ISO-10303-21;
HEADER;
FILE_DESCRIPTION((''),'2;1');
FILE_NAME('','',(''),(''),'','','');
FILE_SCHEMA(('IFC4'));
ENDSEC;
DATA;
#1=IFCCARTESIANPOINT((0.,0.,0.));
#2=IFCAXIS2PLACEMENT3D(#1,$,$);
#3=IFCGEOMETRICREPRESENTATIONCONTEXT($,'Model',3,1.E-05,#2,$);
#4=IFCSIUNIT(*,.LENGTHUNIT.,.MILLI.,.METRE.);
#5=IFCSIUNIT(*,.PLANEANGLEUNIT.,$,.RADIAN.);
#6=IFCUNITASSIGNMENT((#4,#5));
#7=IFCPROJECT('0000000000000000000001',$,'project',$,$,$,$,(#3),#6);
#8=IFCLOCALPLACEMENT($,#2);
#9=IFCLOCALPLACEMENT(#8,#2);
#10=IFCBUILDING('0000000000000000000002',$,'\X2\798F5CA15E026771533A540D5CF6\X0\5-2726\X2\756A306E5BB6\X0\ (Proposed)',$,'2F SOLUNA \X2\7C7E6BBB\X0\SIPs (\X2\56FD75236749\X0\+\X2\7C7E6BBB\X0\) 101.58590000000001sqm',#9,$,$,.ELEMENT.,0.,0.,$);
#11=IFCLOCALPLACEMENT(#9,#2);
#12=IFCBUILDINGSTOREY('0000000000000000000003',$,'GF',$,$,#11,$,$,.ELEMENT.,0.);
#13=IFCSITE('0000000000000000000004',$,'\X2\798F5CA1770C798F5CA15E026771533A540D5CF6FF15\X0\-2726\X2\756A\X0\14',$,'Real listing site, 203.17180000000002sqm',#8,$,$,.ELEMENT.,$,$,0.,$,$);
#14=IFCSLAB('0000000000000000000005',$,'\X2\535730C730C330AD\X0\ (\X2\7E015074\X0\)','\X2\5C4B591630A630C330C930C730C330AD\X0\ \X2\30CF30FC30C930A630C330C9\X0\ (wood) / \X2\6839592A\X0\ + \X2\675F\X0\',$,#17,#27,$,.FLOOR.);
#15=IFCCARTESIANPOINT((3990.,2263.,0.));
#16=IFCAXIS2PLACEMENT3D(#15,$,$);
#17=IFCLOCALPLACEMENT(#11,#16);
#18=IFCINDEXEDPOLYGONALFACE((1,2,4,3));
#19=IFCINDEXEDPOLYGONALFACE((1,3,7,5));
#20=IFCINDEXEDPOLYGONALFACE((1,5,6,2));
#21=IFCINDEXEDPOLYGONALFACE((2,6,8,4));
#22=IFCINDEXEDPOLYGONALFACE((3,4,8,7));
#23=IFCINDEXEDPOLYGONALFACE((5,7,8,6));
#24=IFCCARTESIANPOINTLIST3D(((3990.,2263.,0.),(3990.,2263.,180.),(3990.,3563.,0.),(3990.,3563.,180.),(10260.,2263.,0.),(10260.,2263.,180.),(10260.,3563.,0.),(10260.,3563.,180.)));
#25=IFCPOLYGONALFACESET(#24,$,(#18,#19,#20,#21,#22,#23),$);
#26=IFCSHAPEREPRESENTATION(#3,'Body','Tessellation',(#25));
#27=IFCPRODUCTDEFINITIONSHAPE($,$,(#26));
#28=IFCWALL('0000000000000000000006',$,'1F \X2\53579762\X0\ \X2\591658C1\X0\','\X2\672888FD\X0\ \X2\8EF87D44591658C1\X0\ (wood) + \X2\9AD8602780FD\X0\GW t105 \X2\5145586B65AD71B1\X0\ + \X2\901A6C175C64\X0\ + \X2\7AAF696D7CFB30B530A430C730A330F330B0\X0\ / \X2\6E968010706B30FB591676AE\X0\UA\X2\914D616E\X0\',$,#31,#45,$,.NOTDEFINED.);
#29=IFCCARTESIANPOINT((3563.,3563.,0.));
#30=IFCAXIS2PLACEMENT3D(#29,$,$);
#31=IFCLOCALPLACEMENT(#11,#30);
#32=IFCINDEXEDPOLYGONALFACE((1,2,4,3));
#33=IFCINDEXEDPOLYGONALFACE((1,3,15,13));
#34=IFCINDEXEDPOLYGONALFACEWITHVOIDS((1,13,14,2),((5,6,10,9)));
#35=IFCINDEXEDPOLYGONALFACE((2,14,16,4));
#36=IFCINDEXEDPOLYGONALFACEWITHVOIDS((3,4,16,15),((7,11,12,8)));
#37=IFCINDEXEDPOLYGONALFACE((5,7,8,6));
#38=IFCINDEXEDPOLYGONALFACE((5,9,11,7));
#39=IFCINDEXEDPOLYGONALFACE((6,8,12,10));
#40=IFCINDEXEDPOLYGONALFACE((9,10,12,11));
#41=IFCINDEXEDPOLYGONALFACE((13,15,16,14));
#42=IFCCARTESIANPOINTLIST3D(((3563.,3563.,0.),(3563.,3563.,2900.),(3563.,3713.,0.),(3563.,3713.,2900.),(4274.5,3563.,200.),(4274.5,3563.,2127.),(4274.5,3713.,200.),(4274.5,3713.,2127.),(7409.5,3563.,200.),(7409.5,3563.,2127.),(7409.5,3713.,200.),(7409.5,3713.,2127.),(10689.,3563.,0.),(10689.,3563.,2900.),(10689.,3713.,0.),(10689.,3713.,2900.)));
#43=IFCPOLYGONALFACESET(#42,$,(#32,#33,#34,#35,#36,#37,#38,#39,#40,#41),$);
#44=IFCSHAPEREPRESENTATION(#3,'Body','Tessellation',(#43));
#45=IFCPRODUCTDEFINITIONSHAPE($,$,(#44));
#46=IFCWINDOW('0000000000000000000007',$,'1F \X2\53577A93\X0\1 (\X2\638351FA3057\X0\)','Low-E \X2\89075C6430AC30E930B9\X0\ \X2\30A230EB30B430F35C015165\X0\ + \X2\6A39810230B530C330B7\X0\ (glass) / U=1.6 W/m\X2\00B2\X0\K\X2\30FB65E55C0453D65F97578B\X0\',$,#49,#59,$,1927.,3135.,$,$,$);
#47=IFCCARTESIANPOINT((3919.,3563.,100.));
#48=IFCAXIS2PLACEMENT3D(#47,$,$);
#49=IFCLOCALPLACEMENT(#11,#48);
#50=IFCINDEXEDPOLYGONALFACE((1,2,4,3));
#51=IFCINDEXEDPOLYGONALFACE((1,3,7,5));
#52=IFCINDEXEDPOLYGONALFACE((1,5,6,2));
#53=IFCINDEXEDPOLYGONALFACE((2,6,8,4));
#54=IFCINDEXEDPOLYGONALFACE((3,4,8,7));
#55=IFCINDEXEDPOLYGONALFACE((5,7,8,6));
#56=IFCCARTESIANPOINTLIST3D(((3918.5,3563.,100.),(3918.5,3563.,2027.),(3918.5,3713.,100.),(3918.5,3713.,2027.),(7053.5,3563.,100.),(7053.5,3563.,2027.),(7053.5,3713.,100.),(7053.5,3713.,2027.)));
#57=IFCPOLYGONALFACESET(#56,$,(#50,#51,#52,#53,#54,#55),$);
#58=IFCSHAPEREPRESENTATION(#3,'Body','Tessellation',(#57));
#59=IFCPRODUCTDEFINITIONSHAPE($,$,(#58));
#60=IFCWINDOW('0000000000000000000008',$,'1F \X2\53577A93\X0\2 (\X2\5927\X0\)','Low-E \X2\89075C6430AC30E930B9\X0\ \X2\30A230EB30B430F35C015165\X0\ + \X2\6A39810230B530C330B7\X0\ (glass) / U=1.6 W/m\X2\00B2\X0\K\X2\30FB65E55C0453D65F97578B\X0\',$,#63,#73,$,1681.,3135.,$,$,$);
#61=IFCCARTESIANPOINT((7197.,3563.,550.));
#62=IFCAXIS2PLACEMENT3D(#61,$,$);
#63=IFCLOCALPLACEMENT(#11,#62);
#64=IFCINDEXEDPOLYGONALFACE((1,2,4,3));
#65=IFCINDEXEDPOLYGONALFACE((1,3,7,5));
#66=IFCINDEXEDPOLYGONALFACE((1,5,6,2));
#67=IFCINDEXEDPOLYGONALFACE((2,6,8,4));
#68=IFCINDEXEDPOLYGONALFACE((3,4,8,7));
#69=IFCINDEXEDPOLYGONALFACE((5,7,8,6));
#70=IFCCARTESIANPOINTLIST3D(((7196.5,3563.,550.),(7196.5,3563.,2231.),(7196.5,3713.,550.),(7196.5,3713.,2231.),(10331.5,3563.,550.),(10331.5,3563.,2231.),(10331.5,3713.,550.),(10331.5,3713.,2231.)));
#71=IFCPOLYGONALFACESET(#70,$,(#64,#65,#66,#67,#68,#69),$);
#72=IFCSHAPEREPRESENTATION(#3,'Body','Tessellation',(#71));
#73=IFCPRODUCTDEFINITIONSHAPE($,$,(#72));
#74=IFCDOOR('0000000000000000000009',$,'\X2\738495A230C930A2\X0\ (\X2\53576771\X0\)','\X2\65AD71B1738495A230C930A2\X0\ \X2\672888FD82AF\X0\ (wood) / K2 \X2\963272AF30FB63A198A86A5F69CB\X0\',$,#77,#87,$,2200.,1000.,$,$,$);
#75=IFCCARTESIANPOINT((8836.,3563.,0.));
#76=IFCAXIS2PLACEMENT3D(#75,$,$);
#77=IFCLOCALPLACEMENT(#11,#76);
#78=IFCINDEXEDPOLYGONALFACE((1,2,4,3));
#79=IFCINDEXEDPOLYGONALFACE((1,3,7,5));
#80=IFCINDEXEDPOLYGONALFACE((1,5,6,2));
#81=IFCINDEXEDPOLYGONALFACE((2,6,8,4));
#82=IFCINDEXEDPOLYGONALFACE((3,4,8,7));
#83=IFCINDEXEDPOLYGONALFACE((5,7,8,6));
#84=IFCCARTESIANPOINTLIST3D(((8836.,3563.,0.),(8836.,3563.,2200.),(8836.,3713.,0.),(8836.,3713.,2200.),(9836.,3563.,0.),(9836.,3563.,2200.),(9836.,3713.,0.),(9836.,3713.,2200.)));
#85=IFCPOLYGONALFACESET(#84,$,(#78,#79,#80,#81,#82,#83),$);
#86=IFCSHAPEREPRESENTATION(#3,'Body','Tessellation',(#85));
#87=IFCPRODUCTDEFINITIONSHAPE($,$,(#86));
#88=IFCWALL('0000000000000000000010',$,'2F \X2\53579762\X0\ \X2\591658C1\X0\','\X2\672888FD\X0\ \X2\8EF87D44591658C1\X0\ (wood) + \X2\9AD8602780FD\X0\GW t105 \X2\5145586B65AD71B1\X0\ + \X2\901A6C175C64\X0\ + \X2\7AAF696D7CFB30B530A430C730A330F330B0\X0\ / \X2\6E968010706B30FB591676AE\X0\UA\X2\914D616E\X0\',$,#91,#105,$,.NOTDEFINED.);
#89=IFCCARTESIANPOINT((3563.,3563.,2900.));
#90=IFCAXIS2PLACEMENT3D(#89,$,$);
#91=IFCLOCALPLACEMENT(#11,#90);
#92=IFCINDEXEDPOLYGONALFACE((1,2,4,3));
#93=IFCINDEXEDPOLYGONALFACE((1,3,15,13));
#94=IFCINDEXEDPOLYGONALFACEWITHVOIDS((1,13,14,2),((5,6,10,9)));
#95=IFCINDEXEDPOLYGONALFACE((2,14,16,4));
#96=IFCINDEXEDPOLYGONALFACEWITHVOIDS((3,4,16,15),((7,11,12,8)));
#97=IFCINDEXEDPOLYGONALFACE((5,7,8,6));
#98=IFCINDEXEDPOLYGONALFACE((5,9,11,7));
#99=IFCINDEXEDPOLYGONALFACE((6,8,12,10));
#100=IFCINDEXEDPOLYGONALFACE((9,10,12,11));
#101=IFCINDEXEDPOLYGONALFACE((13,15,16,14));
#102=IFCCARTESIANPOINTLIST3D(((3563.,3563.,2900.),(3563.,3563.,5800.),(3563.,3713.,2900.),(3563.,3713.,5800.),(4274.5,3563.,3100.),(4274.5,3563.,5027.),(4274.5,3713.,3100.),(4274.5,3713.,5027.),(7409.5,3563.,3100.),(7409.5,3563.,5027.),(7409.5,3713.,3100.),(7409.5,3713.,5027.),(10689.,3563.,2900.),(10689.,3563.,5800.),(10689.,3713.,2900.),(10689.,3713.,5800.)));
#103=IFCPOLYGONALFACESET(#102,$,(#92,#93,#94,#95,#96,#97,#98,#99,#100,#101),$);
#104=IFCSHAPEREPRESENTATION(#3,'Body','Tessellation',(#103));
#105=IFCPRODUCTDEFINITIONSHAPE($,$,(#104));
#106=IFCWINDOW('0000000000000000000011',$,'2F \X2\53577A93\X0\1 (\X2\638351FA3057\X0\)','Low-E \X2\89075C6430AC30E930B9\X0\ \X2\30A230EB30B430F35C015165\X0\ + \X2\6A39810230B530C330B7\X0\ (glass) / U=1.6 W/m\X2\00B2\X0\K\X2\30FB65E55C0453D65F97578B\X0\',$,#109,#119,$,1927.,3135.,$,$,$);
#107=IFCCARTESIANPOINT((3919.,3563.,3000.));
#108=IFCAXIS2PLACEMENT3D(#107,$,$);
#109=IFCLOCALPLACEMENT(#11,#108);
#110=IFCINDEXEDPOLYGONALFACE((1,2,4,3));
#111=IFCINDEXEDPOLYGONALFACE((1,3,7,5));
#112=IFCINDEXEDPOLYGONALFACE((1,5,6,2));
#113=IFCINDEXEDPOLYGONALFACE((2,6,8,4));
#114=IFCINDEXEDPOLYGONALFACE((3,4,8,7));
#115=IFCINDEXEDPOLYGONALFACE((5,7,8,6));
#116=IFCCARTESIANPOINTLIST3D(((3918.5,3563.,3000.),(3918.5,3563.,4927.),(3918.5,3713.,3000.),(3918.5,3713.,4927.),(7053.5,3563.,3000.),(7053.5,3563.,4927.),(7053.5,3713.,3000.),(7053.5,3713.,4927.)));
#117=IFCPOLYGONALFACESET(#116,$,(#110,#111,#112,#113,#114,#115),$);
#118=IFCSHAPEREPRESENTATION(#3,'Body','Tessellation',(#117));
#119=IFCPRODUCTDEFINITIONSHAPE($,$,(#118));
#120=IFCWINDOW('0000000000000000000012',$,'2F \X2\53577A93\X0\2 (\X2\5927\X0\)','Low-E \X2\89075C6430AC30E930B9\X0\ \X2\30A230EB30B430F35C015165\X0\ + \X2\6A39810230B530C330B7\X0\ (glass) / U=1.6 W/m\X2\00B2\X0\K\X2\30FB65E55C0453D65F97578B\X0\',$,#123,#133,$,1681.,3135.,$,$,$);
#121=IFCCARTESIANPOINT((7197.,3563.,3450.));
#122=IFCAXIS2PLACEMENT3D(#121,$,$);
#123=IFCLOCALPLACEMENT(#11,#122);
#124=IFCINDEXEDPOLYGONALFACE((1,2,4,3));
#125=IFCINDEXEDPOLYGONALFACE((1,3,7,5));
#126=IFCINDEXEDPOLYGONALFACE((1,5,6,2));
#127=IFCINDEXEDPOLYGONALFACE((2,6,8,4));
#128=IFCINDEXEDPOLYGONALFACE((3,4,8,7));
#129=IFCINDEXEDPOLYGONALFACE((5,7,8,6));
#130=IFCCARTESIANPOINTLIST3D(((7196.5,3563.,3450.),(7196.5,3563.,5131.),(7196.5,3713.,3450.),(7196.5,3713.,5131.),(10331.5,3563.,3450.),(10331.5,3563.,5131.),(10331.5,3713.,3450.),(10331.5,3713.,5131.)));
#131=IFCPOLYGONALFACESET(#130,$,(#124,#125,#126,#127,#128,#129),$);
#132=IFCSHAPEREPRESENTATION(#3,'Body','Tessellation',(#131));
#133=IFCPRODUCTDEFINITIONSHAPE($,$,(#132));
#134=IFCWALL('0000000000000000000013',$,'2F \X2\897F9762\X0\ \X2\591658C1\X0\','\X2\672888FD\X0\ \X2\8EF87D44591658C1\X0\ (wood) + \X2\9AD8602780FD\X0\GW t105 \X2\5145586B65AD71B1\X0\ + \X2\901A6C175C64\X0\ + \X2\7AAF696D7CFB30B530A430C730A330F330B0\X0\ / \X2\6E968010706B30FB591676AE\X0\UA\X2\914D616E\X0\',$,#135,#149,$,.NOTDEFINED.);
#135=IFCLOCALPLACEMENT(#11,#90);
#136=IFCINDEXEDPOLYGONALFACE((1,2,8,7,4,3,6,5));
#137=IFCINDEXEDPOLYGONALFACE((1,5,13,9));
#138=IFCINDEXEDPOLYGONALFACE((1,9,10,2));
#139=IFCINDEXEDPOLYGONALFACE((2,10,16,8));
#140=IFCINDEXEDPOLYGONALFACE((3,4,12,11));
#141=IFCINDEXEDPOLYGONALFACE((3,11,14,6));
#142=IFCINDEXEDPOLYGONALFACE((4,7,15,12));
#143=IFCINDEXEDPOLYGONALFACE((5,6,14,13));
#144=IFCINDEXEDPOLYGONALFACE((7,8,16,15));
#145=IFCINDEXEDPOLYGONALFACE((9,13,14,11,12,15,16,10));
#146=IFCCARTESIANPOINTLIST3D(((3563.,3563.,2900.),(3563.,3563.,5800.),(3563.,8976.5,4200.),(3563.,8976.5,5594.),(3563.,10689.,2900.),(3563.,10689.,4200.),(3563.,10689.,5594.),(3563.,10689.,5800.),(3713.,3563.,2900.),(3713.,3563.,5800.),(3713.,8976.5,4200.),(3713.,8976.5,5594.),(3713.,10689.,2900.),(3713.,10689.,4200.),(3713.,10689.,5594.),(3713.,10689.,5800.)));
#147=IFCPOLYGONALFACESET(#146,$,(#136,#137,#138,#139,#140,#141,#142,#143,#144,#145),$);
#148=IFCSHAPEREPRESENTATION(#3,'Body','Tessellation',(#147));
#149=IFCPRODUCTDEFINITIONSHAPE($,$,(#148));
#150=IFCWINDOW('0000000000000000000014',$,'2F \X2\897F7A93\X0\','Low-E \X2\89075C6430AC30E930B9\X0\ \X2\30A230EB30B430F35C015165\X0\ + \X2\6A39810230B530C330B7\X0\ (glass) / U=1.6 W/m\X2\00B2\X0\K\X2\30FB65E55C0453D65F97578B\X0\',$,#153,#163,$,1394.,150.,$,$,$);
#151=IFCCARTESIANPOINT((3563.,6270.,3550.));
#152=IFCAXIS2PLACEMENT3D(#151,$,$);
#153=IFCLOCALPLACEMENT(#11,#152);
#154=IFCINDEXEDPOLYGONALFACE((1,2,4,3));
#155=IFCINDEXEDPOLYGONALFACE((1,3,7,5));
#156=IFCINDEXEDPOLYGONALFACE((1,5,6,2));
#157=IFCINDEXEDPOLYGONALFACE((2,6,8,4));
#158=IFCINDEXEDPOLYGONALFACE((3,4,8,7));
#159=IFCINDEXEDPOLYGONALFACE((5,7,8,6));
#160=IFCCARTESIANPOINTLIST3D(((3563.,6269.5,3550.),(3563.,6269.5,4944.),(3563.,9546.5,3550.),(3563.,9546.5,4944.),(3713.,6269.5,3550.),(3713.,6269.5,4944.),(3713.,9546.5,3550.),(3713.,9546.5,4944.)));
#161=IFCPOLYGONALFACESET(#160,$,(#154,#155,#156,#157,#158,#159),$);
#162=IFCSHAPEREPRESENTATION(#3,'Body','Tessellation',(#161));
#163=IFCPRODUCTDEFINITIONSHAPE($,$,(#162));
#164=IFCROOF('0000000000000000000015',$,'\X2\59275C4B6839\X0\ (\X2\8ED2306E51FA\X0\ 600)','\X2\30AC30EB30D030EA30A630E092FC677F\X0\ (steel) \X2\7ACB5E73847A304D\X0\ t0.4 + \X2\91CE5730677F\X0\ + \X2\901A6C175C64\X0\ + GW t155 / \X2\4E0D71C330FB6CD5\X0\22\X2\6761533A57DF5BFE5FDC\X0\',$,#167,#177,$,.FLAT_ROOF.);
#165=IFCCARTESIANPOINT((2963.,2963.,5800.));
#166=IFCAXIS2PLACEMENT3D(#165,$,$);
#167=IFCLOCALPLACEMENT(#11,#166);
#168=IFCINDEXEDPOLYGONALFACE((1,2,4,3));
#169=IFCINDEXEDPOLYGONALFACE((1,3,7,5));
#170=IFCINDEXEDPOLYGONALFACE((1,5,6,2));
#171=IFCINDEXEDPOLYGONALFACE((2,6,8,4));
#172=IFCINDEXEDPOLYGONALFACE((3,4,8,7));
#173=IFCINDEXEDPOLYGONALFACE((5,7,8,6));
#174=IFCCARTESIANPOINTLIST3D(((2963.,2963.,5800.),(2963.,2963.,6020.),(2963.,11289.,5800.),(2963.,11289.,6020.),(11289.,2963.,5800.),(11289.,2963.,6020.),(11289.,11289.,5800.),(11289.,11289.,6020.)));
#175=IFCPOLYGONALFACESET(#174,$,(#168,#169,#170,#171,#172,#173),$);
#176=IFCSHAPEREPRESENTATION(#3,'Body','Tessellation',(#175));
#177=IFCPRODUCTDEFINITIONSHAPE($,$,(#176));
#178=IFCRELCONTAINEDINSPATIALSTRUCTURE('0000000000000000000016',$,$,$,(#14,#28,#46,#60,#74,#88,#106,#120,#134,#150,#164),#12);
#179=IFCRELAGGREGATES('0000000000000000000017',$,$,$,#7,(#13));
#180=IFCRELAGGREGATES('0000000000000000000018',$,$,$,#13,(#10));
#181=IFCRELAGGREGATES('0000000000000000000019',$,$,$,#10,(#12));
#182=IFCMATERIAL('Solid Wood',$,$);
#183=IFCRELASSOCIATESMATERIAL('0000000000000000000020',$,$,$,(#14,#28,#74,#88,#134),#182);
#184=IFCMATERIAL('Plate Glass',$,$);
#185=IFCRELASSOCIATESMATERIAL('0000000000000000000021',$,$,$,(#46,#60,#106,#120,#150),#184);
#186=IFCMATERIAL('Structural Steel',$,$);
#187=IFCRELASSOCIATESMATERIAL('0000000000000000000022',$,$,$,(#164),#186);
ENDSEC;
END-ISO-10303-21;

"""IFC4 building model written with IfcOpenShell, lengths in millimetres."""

from ifc_helpers import new_model, si_unit, frame, frame_2d, origin, place, context, project, spatial, rectangle, extrude, material, element, fill, save


model = new_model("IFC4")

# Units and contexts
model_context = context("Model", 3, precision=1e-05, world=origin())
ifc_project = project(units=[si_unit("LENGTHUNIT", "METRE", prefix="MILLI"), si_unit("PLANEANGLEUNIT", "RADIAN")], contexts=[model_context])

# Site, building, storey
site_placement = place(None, origin())
site = spatial("IfcSite", under=ifc_project, at=site_placement, Name="福岡県福岡市東区名島５-2726番14", ObjectType="Real listing site, 203.17180000000002sqm", CompositionType="ELEMENT", RefElevation=0.0)
building_placement = place(site_placement, origin())
building = spatial("IfcBuilding", under=site, at=building_placement, Name="福岡市東区名島5-2726番の家 (Proposed)", ObjectType="2F SOLUNA 籾殻SIPs (国産杉+籾殻) 101.58590000000001sqm", CompositionType="ELEMENT", ElevationOfRefHeight=0.0, ElevationOfTerrain=0.0)
storey_placement = place(building_placement, origin())
storey = spatial("IfcBuildingStorey", under=building, at=storey_placement, Name="GF", CompositionType="ELEMENT", Elevation=0.0)

# Slab
ifc_material_1 = material(Name="Solid Wood")
slab_1_placement = place(storey_placement, frame((3990.0, 2263.0, 0.0)))
element("IfcSlab", 1, at=slab_1_placement, inside=storey, material=ifc_material_1, Name="南デッキ (縁側)", Description="屋外ウッドデッキ ハードウッド (wood) / 根太 + 束", PredefinedType="FLOOR", context=model_context, shape_type="SweptSolid", body=[
    extrude(rectangle(XDim=6270.0, YDim=1300.0, at=frame_2d((3135.0, 650.0))), frame((3990.0, 2263.0, 0.0)), (0.0, 0.0, 1.0), 180.0),
])

# Wall, openings, windows, door
wall_1_placement = place(storey_placement, frame((3563.0, 3563.0, 0.0)))
wall_1 = element("IfcWall", 2, at=wall_1_placement, inside=storey, material=ifc_material_1, Name="1F 南面 外壁", Description="木製 軸組外壁 (wood) + 高性能GW t105 充填断熱 + 通気層 + 窯業系サイディング / 準耐火・外皮UA配慮", PredefinedType="NOTDEFINED", context=model_context, shape_type="SweptSolid", body=[
    extrude(rectangle(XDim=7126.0, YDim=150.0, at=frame_2d((3563.0, 75.0))), frame((3563.0, 3563.0, 0.0)), (0.0, 0.0, 1.0), 2900.0),
])
opening_1_placement = place(storey_placement, frame((3919.0, 3563.0, 100.0)))
opening_1 = element("IfcOpeningElement", 3, at=opening_1_placement, cuts=wall_1, PredefinedType="NOTDEFINED", context=model_context, shape_type="SweptSolid", body=[
    extrude(rectangle(XDim=3135.0, YDim=150.0, at=frame_2d((1567.0, 75.0))), frame((3919.0, 3563.0, 100.0)), (0.0, 0.0, 1.0), 1927.0),
])
opening_2_placement = place(storey_placement, frame((7197.0, 3563.0, 550.0)))
opening_2 = element("IfcOpeningElement", 4, at=opening_2_placement, cuts=wall_1, PredefinedType="NOTDEFINED", context=model_context, shape_type="SweptSolid", body=[
    extrude(rectangle(XDim=3135.0, YDim=150.0, at=frame_2d((1567.0, 75.0))), frame((7197.0, 3563.0, 550.0)), (0.0, 0.0, 1.0), 1681.0),
])
opening_3_placement = place(storey_placement, frame((8836.0, 3563.0, 0.0)))
opening_3 = element("IfcOpeningElement", 5, at=opening_3_placement, cuts=wall_1, PredefinedType="NOTDEFINED", context=model_context, shape_type="SweptSolid", body=[
    extrude(rectangle(XDim=1000.0, YDim=150.0, at=frame_2d((500.0, 75.0))), frame((8836.0, 3563.0, 0.0)), (0.0, 0.0, 1.0), 2200.0),
])
ifc_material_2 = material(Name="Plate Glass")
window_1_placement = place(storey_placement, frame((3919.0, 3563.0, 100.0)))
window_1 = element("IfcWindow", 6, at=window_1_placement, inside=storey, material=ifc_material_2, Name="1F 南窓1 (掃出し)", Description="Low-E 複層ガラス アルゴン封入 + 樹脂サッシ (glass) / U=1.6 W/m²K・日射取得型", OverallHeight=1927.0, OverallWidth=3135.0, context=model_context, shape_type="SweptSolid", body=[
    extrude(rectangle(XDim=3135.0, YDim=150.0, at=frame_2d((1567.0, 75.0))), frame((3919.0, 3563.0, 100.0)), (0.0, 0.0, 1.0), 1927.0),
])
fill(opening_1, window_1)
window_2_placement = place(storey_placement, frame((7197.0, 3563.0, 550.0)))
window_2 = element("IfcWindow", 7, at=window_2_placement, inside=storey, material=ifc_material_2, Name="1F 南窓2 (大)", Description="Low-E 複層ガラス アルゴン封入 + 樹脂サッシ (glass) / U=1.6 W/m²K・日射取得型", OverallHeight=1681.0, OverallWidth=3135.0, context=model_context, shape_type="SweptSolid", body=[
    extrude(rectangle(XDim=3135.0, YDim=150.0, at=frame_2d((1567.0, 75.0))), frame((7197.0, 3563.0, 550.0)), (0.0, 0.0, 1.0), 1681.0),
])
fill(opening_2, window_2)
door_placement = place(storey_placement, frame((8836.0, 3563.0, 0.0)))
door = element("IfcDoor", 8, at=door_placement, inside=storey, material=ifc_material_1, Name="玄関ドア (南東)", Description="断熱玄関ドア 木製芯 (wood) / K2 防犯・採風機構", OverallHeight=2200.0, OverallWidth=1000.0, context=model_context, shape_type="SweptSolid", body=[
    extrude(rectangle(XDim=1000.0, YDim=150.0, at=frame_2d((500.0, 75.0))), frame((8836.0, 3563.0, 0.0)), (0.0, 0.0, 1.0), 2200.0),
])
fill(opening_3, door)

# Wall, openings, windows
wall_2_placement = place(storey_placement, frame((3563.0, 3563.0, 2900.0)))
wall_2 = element("IfcWall", 9, at=wall_2_placement, inside=storey, material=ifc_material_1, Name="2F 南面 外壁", Description="木製 軸組外壁 (wood) + 高性能GW t105 充填断熱 + 通気層 + 窯業系サイディング / 準耐火・外皮UA配慮", PredefinedType="NOTDEFINED", context=model_context, shape_type="SweptSolid", body=[
    extrude(rectangle(XDim=7126.0, YDim=150.0, at=frame_2d((3563.0, 75.0))), frame((3563.0, 3563.0, 2900.0)), (0.0, 0.0, 1.0), 2900.0),
])
opening_4_placement = place(storey_placement, frame((3919.0, 3563.0, 3000.0)))
opening_4 = element("IfcOpeningElement", 10, at=opening_4_placement, cuts=wall_2, PredefinedType="NOTDEFINED", context=model_context, shape_type="SweptSolid", body=[
    extrude(rectangle(XDim=3135.0, YDim=150.0, at=frame_2d((1567.0, 75.0))), frame((3919.0, 3563.0, 3000.0)), (0.0, 0.0, 1.0), 1927.0),
])
opening_5_placement = place(storey_placement, frame((7197.0, 3563.0, 3450.0)))
opening_5 = element("IfcOpeningElement", 11, at=opening_5_placement, cuts=wall_2, PredefinedType="NOTDEFINED", context=model_context, shape_type="SweptSolid", body=[
    extrude(rectangle(XDim=3135.0, YDim=150.0, at=frame_2d((1567.0, 75.0))), frame((7197.0, 3563.0, 3450.0)), (0.0, 0.0, 1.0), 1681.0),
])
window_3_placement = place(storey_placement, frame((3919.0, 3563.0, 3000.0)))
window_3 = element("IfcWindow", 12, at=window_3_placement, inside=storey, material=ifc_material_2, Name="2F 南窓1 (掃出し)", Description="Low-E 複層ガラス アルゴン封入 + 樹脂サッシ (glass) / U=1.6 W/m²K・日射取得型", OverallHeight=1927.0, OverallWidth=3135.0, context=model_context, shape_type="SweptSolid", body=[
    extrude(rectangle(XDim=3135.0, YDim=150.0, at=frame_2d((1567.0, 75.0))), frame((3919.0, 3563.0, 3000.0)), (0.0, 0.0, 1.0), 1927.0),
])
fill(opening_4, window_3)
window_4_placement = place(storey_placement, frame((7197.0, 3563.0, 3450.0)))
window_4 = element("IfcWindow", 13, at=window_4_placement, inside=storey, material=ifc_material_2, Name="2F 南窓2 (大)", Description="Low-E 複層ガラス アルゴン封入 + 樹脂サッシ (glass) / U=1.6 W/m²K・日射取得型", OverallHeight=1681.0, OverallWidth=3135.0, context=model_context, shape_type="SweptSolid", body=[
    extrude(rectangle(XDim=3135.0, YDim=150.0, at=frame_2d((1567.0, 75.0))), frame((7197.0, 3563.0, 3450.0)), (0.0, 0.0, 1.0), 1681.0),
])
fill(opening_5, window_4)

# Wall, opening, window
wall_3_placement = place(storey_placement, frame((3563.0, 3563.0, 2900.0)))
wall_3 = element("IfcWall", 14, at=wall_3_placement, inside=storey, material=ifc_material_1, Name="2F 西面 外壁", Description="木製 軸組外壁 (wood) + 高性能GW t105 充填断熱 + 通気層 + 窯業系サイディング / 準耐火・外皮UA配慮", PredefinedType="NOTDEFINED", context=model_context, shape_type="SweptSolid", body=[
    extrude(rectangle(XDim=150.0, YDim=7126.0, at=frame_2d((75.0, 3563.0))), frame((3563.0, 3563.0, 2900.0)), (0.0, 0.0, 1.0), 2900.0),
])
opening_6_placement = place(storey_placement, frame((3563.0, 6270.0, 3550.0)))
opening_6 = element("IfcOpeningElement", 15, at=opening_6_placement, cuts=wall_3, PredefinedType="NOTDEFINED", context=model_context, shape_type="SweptSolid", body=[
    extrude(rectangle(XDim=150.0, YDim=3277.0, at=frame_2d((75.0, 1638.0))), frame((3563.0, 6270.0, 3550.0)), (0.0, 0.0, 1.0), 1394.0),
])
window_5_placement = place(storey_placement, frame((3563.0, 6270.0, 3550.0)))
window_5 = element("IfcWindow", 16, at=window_5_placement, inside=storey, material=ifc_material_2, Name="2F 西窓", Description="Low-E 複層ガラス アルゴン封入 + 樹脂サッシ (glass) / U=1.6 W/m²K・日射取得型", OverallHeight=1394.0, OverallWidth=150.0, context=model_context, shape_type="SweptSolid", body=[
    extrude(rectangle(XDim=150.0, YDim=3277.0, at=frame_2d((75.0, 1638.0))), frame((3563.0, 6270.0, 3550.0)), (0.0, 0.0, 1.0), 1394.0),
])
fill(opening_6, window_5)

# Roof
ifc_material_3 = material(Name="Structural Steel")
roof_placement = place(storey_placement, frame((2963.0, 2963.0, 5800.0)))
element("IfcRoof", 17, at=roof_placement, inside=storey, material=ifc_material_3, Name="大屋根 (軒の出 600)", Description="ガルバリウム鋼板 (steel) 立平葺き t0.4 + 野地板 + 通気層 + GW t155 / 不燃・法22条区域対応", PredefinedType="FLAT_ROOF", context=model_context, shape_type="SweptSolid", body=[
    extrude(rectangle(XDim=8326.0, YDim=8326.0, at=frame_2d((4163.0, 4163.0))), frame((2963.0, 2963.0, 5800.0)), (0.0, 0.0, 1.0), 220.0),
])

save(model, "model.ifc")
